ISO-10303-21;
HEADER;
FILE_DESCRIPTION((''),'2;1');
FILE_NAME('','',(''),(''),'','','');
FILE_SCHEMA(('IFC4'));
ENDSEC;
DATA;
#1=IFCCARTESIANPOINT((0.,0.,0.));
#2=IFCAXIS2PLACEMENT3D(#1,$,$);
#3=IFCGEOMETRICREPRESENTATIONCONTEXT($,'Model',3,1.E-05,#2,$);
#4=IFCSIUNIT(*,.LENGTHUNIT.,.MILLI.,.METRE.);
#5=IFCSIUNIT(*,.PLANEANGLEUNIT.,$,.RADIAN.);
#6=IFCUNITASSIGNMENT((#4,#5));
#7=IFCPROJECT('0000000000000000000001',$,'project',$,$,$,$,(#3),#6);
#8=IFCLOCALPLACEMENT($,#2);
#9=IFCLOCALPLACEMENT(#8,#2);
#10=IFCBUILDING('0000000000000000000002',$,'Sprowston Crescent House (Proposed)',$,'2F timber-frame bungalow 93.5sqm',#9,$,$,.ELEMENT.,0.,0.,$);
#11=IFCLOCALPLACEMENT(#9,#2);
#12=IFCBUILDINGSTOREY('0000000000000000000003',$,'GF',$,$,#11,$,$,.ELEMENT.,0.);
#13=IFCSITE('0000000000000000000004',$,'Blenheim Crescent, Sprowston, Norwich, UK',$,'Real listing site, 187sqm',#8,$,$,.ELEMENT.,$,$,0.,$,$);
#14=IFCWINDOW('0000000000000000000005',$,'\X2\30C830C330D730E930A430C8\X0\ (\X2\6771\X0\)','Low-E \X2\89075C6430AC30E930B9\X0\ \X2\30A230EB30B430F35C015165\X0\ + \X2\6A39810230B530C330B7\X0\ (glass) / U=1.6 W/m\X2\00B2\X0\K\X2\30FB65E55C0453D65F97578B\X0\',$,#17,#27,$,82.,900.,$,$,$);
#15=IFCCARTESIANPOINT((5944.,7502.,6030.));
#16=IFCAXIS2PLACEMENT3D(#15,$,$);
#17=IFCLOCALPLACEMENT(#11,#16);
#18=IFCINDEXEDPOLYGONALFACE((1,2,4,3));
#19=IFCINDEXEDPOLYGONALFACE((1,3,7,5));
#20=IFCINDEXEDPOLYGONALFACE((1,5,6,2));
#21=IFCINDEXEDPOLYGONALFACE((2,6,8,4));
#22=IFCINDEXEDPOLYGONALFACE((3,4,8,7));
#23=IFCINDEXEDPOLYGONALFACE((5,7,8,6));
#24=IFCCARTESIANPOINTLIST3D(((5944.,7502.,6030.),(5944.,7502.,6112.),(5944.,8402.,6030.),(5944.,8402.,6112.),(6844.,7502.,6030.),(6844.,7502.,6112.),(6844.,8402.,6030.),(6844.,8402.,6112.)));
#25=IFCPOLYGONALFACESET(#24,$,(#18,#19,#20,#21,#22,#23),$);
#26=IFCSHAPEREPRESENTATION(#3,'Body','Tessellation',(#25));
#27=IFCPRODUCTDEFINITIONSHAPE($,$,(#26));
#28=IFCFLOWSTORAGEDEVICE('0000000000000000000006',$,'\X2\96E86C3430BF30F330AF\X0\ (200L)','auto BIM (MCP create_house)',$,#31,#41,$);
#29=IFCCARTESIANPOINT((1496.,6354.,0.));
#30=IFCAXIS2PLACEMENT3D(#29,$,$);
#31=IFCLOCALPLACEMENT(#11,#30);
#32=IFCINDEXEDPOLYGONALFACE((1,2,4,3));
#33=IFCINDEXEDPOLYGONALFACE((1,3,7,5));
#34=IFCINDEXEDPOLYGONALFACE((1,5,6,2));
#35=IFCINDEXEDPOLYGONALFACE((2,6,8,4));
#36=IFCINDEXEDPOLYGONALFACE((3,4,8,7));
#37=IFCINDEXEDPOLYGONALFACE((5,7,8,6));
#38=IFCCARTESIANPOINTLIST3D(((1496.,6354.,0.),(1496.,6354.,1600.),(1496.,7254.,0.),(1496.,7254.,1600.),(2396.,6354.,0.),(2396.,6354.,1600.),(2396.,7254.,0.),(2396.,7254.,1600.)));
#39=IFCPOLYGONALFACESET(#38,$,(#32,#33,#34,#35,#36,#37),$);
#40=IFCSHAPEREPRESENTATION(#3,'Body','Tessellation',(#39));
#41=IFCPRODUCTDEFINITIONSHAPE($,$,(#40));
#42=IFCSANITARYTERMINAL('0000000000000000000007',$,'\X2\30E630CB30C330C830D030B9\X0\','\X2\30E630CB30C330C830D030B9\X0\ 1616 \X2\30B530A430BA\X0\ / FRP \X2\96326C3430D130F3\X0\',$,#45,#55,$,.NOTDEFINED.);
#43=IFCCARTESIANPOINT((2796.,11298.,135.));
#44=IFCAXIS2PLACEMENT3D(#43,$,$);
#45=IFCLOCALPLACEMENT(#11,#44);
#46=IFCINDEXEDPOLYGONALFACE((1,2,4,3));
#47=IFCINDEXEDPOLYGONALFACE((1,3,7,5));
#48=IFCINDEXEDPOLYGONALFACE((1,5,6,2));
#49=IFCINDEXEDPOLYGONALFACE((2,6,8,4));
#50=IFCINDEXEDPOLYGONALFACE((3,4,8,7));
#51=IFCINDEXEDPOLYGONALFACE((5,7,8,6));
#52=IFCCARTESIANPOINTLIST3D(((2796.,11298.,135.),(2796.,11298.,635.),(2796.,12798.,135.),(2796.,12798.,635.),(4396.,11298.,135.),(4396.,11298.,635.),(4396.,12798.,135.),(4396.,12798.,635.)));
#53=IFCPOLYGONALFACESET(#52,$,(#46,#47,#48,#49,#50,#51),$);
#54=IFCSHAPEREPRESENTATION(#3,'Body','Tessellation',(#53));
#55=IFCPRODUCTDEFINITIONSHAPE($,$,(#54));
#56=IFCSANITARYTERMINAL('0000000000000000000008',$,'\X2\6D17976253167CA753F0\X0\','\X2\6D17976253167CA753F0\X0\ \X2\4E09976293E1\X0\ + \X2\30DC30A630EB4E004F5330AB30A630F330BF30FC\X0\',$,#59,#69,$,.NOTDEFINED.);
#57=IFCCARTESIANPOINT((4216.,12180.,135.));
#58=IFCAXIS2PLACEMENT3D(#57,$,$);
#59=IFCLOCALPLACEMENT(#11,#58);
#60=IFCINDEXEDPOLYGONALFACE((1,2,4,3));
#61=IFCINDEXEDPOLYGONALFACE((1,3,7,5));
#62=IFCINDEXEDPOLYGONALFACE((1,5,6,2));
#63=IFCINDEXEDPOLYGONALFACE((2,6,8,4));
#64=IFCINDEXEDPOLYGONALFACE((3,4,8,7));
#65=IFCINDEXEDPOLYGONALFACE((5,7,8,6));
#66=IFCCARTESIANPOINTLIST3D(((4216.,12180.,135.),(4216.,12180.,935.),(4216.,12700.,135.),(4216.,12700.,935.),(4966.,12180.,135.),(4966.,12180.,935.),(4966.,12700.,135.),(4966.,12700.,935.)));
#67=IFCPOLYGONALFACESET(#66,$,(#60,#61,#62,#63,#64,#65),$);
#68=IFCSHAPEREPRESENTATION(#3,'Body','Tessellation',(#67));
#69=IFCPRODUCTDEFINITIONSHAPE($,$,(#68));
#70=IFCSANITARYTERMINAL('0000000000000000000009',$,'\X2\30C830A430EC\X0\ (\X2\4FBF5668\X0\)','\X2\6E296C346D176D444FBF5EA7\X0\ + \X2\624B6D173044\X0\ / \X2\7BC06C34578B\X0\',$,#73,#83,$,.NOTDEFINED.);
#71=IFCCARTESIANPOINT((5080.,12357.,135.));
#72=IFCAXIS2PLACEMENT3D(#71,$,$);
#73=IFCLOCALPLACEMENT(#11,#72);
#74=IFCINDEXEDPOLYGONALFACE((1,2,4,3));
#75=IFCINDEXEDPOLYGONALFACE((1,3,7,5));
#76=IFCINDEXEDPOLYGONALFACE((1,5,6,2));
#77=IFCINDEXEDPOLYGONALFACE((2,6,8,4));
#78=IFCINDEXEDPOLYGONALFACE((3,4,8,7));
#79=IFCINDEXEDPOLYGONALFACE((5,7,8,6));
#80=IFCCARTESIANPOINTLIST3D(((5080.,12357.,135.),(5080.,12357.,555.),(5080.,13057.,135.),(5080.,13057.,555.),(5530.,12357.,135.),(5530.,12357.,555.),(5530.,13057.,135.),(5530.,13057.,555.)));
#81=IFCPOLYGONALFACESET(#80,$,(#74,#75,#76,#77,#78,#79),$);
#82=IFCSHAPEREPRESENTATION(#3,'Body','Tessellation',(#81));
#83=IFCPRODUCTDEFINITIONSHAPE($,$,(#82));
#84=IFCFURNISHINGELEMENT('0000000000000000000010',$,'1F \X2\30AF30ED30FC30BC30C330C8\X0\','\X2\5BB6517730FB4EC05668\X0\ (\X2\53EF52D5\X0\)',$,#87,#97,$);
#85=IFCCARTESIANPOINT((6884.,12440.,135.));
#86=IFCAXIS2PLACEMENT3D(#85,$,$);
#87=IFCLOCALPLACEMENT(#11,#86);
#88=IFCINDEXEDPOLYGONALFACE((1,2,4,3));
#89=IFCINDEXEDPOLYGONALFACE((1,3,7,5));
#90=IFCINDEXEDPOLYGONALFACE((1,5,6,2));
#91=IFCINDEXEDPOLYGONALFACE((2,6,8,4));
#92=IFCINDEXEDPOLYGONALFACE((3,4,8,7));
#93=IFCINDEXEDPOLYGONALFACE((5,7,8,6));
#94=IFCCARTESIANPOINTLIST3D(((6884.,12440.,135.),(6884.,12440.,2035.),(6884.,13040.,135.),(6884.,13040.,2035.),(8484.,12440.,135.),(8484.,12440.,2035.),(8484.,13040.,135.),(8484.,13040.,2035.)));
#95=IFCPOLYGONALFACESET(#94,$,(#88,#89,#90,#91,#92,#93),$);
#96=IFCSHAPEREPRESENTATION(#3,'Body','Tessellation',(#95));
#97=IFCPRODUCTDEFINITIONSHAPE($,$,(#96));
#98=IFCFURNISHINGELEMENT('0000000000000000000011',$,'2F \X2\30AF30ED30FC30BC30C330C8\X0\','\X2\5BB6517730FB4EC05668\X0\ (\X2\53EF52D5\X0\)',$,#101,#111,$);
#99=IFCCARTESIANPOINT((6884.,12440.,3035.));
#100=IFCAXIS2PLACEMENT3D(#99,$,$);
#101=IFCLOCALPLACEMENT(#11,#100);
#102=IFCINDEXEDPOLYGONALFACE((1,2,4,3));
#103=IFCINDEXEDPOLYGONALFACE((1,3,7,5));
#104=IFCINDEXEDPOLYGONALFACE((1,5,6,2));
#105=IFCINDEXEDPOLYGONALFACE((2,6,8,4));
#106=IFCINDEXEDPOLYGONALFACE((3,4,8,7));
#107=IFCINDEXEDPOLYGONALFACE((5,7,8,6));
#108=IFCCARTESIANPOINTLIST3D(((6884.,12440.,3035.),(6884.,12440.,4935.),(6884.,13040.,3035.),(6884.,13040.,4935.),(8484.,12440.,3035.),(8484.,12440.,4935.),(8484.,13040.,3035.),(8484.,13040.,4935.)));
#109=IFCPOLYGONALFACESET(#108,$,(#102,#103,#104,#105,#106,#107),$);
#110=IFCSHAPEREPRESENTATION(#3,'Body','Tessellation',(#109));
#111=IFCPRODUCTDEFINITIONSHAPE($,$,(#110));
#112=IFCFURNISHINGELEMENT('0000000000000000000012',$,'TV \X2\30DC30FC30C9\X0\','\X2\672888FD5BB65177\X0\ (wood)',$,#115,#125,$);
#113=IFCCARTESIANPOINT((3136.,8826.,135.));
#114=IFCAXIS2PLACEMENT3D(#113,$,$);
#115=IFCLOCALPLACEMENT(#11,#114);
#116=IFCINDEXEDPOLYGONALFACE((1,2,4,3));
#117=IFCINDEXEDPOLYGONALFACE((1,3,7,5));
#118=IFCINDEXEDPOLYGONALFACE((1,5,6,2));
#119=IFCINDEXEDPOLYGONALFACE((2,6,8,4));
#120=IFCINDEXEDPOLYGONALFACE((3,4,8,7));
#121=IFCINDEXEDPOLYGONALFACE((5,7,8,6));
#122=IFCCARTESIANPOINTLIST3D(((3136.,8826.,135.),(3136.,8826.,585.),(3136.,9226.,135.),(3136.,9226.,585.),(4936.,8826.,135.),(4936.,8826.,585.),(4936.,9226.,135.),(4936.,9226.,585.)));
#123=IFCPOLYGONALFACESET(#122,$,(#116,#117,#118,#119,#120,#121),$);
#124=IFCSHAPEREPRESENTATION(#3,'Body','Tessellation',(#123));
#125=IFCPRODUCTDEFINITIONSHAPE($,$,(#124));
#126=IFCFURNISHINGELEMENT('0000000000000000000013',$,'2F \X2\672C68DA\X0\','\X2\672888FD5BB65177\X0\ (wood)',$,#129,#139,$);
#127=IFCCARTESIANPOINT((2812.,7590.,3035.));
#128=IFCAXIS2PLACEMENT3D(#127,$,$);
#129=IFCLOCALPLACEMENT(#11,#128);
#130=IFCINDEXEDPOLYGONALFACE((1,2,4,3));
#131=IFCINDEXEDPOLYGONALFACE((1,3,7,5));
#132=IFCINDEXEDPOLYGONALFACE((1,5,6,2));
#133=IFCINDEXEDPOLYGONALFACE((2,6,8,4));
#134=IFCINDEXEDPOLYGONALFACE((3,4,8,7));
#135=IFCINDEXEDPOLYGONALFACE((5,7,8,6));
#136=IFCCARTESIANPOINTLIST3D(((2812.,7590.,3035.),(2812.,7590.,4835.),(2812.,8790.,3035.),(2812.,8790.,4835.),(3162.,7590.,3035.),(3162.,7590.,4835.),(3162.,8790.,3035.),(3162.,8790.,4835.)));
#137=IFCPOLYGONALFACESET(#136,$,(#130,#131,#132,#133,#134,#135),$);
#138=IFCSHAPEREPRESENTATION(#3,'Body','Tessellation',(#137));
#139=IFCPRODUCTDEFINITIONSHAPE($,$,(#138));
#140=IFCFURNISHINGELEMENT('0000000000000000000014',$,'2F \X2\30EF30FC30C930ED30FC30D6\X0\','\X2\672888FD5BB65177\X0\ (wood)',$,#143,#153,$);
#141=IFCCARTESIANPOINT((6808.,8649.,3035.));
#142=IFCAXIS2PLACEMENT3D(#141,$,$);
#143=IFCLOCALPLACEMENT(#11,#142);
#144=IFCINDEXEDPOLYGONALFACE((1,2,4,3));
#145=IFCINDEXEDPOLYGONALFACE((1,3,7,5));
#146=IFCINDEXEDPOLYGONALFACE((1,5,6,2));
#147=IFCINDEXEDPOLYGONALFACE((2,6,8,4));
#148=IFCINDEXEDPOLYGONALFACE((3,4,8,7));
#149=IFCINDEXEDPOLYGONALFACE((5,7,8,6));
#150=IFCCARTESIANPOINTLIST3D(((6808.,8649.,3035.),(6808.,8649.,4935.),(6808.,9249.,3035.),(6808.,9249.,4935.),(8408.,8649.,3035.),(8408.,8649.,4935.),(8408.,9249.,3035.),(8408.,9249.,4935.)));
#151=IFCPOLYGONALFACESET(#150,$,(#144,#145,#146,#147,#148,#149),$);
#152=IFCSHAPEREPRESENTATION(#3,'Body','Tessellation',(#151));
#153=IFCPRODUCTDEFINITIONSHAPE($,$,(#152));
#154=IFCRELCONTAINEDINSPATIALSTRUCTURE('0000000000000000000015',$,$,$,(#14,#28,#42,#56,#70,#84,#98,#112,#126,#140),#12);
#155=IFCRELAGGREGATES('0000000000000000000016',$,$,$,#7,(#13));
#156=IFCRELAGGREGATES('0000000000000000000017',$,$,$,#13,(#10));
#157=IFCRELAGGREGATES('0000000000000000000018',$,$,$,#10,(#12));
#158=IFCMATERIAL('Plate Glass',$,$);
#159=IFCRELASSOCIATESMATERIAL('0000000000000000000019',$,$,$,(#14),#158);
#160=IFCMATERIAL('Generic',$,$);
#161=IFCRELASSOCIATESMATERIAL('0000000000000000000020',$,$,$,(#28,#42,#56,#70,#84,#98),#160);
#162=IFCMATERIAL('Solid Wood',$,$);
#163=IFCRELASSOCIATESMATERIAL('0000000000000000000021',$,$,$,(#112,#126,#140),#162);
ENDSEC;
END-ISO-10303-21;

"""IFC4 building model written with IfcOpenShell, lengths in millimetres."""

from ifc_helpers import new_model, si_unit, frame, frame_2d, origin, place, context, project, spatial, rectangle, extrude, material, element, save


model = new_model("IFC4")

# Units and contexts
model_context = context("Model", 3, precision=1e-05, world=origin())
ifc_project = project(units=[si_unit("LENGTHUNIT", "METRE", prefix="MILLI"), si_unit("PLANEANGLEUNIT", "RADIAN")], contexts=[model_context])

# Site, building, storey
site_placement = place(None, origin())
site = spatial("IfcSite", under=ifc_project, at=site_placement, Name="Blenheim Crescent, Sprowston, Norwich, UK", ObjectType="Real listing site, 187sqm", CompositionType="ELEMENT", RefElevation=0.0)
building_placement = place(site_placement, origin())
building = spatial("IfcBuilding", under=site, at=building_placement, Name="Sprowston Crescent House (Proposed)", ObjectType="2F timber-frame bungalow 93.5sqm", CompositionType="ELEMENT", ElevationOfRefHeight=0.0, ElevationOfTerrain=0.0)
storey_placement = place(building_placement, origin())
storey = spatial("IfcBuildingStorey", under=building, at=storey_placement, Name="GF", CompositionType="ELEMENT", Elevation=0.0)

# Shared definitions
ifc_material_1 = material(Name="Solid Wood")
ifc_material_2 = material(Name="Plate Glass")

# Window
window_1_placement = place(storey_placement, frame((5944.0, 7502.0, 6030.0)))
element("IfcWindow", 1, at=window_1_placement, inside=storey, material=ifc_material_2, Name="トップライト (東)", Description="Low-E 複層ガラス アルゴン封入 + 樹脂サッシ (glass) / U=1.6 W/m²K・日射取得型", OverallHeight=82.0, OverallWidth=900.0, context=model_context, shape_type="SweptSolid", body=[
    extrude(rectangle(XDim=900.0, YDim=900.0, at=frame_2d((450.0, 450.0))), frame((5944.0, 7502.0, 6030.0)), (0.0, 0.0, 1.0), 82.0),
])

# Flow storage device
ifc_material_3 = material(Name="Generic")
flow_storage_device_placement = place(storey_placement, frame((1496.0, 6354.0, 0.0)))
element("IfcFlowStorageDevice", 2, at=flow_storage_device_placement, inside=storey, material=ifc_material_3, Name="雨水タンク (200L)", Description="auto BIM (MCP create_house)", context=model_context, shape_type="SweptSolid", body=[
    extrude(rectangle(XDim=900.0, YDim=900.0, at=frame_2d((450.0, 450.0))), frame((1496.0, 6354.0, 0.0)), (0.0, 0.0, 1.0), 1600.0),
])

# Sanitary terminals
sanitary_terminal_1_placement = place(storey_placement, frame((2796.0, 11298.0, 135.0)))
element("IfcSanitaryTerminal", 3, at=sanitary_terminal_1_placement, inside=storey, material=ifc_material_3, Name="ユニットバス", Description="ユニットバス 1616 サイズ / FRP 防水パン", PredefinedType="NOTDEFINED", context=model_context, shape_type="SweptSolid", body=[
    extrude(rectangle(XDim=1600.0, YDim=1500.0, at=frame_2d((800.0, 750.0))), frame((2796.0, 11298.0, 135.0)), (0.0, 0.0, 1.0), 500.0),
])
sanitary_terminal_2_placement = place(storey_placement, frame((4216.0, 12180.0, 135.0)))
element("IfcSanitaryTerminal", 4, at=sanitary_terminal_2_placement, inside=storey, material=ifc_material_3, Name="洗面化粧台", Description="洗面化粧台 三面鏡 + ボウル一体カウンター", PredefinedType="NOTDEFINED", context=model_context, shape_type="SweptSolid", body=[
    extrude(rectangle(XDim=750.0, YDim=520.0, at=frame_2d((375.0, 260.0))), frame((4216.0, 12180.0, 135.0)), (0.0, 0.0, 1.0), 800.0),
])
sanitary_terminal_3_placement = place(storey_placement, frame((5080.0, 12357.0, 135.0)))
element("IfcSanitaryTerminal", 5, at=sanitary_terminal_3_placement, inside=storey, material=ifc_material_3, Name="トイレ (便器)", Description="温水洗浄便座 + 手洗い / 節水型", PredefinedType="NOTDEFINED", context=model_context, shape_type="SweptSolid", body=[
    extrude(rectangle(XDim=450.0, YDim=700.0, at=frame_2d((225.0, 350.0))), frame((5080.0, 12357.0, 135.0)), (0.0, 0.0, 1.0), 420.0),
])

# Furnishing elements
furnishing_1_placement = place(storey_placement, frame((6884.0, 12440.0, 135.0)))
element("IfcFurnishingElement", 6, at=furnishing_1_placement, inside=storey, material=ifc_material_3, Name="1F クローゼット", Description="家具・什器 (可動)", context=model_context, shape_type="SweptSolid", body=[
    extrude(rectangle(XDim=1600.0, YDim=600.0, at=frame_2d((800.0, 300.0))), frame((6884.0, 12440.0, 135.0)), (0.0, 0.0, 1.0), 1900.0),
])
furnishing_2_placement = place(storey_placement, frame((6884.0, 12440.0, 3035.0)))
element("IfcFurnishingElement", 7, at=furnishing_2_placement, inside=storey, material=ifc_material_3, Name="2F クローゼット", Description="家具・什器 (可動)", context=model_context, shape_type="SweptSolid", body=[
    extrude(rectangle(XDim=1600.0, YDim=600.0, at=frame_2d((800.0, 300.0))), frame((6884.0, 12440.0, 3035.0)), (0.0, 0.0, 1.0), 1900.0),
])
furnishing_3_placement = place(storey_placement, frame((3136.0, 8826.0, 135.0)))
element("IfcFurnishingElement", 8, at=furnishing_3_placement, inside=storey, material=ifc_material_1, Name="TV ボード", Description="木製家具 (wood)", context=model_context, shape_type="SweptSolid", body=[
    extrude(rectangle(XDim=1800.0, YDim=400.0, at=frame_2d((900.0, 200.0))), frame((3136.0, 8826.0, 135.0)), (0.0, 0.0, 1.0), 450.0),
])
furnishing_4_placement = place(storey_placement, frame((2812.0, 7590.0, 3035.0)))
element("IfcFurnishingElement", 9, at=furnishing_4_placement, inside=storey, material=ifc_material_1, Name="2F 本棚", Description="木製家具 (wood)", context=model_context, shape_type="SweptSolid", body=[
    extrude(rectangle(XDim=350.0, YDim=1200.0, at=frame_2d((175.0, 600.0))), frame((2812.0, 7590.0, 3035.0)), (0.0, 0.0, 1.0), 1800.0),
])
furnishing_5_placement = place(storey_placement, frame((6808.0, 8649.0, 3035.0)))
element("IfcFurnishingElement", 10, at=furnishing_5_placement, inside=storey, material=ifc_material_1, Name="2F ワードローブ", Description="木製家具 (wood)", context=model_context, shape_type="SweptSolid", body=[
    extrude(rectangle(XDim=1600.0, YDim=600.0, at=frame_2d((800.0, 300.0))), frame((6808.0, 8649.0, 3035.0)), (0.0, 0.0, 1.0), 1900.0),
])

save(model, "model.ifc")
